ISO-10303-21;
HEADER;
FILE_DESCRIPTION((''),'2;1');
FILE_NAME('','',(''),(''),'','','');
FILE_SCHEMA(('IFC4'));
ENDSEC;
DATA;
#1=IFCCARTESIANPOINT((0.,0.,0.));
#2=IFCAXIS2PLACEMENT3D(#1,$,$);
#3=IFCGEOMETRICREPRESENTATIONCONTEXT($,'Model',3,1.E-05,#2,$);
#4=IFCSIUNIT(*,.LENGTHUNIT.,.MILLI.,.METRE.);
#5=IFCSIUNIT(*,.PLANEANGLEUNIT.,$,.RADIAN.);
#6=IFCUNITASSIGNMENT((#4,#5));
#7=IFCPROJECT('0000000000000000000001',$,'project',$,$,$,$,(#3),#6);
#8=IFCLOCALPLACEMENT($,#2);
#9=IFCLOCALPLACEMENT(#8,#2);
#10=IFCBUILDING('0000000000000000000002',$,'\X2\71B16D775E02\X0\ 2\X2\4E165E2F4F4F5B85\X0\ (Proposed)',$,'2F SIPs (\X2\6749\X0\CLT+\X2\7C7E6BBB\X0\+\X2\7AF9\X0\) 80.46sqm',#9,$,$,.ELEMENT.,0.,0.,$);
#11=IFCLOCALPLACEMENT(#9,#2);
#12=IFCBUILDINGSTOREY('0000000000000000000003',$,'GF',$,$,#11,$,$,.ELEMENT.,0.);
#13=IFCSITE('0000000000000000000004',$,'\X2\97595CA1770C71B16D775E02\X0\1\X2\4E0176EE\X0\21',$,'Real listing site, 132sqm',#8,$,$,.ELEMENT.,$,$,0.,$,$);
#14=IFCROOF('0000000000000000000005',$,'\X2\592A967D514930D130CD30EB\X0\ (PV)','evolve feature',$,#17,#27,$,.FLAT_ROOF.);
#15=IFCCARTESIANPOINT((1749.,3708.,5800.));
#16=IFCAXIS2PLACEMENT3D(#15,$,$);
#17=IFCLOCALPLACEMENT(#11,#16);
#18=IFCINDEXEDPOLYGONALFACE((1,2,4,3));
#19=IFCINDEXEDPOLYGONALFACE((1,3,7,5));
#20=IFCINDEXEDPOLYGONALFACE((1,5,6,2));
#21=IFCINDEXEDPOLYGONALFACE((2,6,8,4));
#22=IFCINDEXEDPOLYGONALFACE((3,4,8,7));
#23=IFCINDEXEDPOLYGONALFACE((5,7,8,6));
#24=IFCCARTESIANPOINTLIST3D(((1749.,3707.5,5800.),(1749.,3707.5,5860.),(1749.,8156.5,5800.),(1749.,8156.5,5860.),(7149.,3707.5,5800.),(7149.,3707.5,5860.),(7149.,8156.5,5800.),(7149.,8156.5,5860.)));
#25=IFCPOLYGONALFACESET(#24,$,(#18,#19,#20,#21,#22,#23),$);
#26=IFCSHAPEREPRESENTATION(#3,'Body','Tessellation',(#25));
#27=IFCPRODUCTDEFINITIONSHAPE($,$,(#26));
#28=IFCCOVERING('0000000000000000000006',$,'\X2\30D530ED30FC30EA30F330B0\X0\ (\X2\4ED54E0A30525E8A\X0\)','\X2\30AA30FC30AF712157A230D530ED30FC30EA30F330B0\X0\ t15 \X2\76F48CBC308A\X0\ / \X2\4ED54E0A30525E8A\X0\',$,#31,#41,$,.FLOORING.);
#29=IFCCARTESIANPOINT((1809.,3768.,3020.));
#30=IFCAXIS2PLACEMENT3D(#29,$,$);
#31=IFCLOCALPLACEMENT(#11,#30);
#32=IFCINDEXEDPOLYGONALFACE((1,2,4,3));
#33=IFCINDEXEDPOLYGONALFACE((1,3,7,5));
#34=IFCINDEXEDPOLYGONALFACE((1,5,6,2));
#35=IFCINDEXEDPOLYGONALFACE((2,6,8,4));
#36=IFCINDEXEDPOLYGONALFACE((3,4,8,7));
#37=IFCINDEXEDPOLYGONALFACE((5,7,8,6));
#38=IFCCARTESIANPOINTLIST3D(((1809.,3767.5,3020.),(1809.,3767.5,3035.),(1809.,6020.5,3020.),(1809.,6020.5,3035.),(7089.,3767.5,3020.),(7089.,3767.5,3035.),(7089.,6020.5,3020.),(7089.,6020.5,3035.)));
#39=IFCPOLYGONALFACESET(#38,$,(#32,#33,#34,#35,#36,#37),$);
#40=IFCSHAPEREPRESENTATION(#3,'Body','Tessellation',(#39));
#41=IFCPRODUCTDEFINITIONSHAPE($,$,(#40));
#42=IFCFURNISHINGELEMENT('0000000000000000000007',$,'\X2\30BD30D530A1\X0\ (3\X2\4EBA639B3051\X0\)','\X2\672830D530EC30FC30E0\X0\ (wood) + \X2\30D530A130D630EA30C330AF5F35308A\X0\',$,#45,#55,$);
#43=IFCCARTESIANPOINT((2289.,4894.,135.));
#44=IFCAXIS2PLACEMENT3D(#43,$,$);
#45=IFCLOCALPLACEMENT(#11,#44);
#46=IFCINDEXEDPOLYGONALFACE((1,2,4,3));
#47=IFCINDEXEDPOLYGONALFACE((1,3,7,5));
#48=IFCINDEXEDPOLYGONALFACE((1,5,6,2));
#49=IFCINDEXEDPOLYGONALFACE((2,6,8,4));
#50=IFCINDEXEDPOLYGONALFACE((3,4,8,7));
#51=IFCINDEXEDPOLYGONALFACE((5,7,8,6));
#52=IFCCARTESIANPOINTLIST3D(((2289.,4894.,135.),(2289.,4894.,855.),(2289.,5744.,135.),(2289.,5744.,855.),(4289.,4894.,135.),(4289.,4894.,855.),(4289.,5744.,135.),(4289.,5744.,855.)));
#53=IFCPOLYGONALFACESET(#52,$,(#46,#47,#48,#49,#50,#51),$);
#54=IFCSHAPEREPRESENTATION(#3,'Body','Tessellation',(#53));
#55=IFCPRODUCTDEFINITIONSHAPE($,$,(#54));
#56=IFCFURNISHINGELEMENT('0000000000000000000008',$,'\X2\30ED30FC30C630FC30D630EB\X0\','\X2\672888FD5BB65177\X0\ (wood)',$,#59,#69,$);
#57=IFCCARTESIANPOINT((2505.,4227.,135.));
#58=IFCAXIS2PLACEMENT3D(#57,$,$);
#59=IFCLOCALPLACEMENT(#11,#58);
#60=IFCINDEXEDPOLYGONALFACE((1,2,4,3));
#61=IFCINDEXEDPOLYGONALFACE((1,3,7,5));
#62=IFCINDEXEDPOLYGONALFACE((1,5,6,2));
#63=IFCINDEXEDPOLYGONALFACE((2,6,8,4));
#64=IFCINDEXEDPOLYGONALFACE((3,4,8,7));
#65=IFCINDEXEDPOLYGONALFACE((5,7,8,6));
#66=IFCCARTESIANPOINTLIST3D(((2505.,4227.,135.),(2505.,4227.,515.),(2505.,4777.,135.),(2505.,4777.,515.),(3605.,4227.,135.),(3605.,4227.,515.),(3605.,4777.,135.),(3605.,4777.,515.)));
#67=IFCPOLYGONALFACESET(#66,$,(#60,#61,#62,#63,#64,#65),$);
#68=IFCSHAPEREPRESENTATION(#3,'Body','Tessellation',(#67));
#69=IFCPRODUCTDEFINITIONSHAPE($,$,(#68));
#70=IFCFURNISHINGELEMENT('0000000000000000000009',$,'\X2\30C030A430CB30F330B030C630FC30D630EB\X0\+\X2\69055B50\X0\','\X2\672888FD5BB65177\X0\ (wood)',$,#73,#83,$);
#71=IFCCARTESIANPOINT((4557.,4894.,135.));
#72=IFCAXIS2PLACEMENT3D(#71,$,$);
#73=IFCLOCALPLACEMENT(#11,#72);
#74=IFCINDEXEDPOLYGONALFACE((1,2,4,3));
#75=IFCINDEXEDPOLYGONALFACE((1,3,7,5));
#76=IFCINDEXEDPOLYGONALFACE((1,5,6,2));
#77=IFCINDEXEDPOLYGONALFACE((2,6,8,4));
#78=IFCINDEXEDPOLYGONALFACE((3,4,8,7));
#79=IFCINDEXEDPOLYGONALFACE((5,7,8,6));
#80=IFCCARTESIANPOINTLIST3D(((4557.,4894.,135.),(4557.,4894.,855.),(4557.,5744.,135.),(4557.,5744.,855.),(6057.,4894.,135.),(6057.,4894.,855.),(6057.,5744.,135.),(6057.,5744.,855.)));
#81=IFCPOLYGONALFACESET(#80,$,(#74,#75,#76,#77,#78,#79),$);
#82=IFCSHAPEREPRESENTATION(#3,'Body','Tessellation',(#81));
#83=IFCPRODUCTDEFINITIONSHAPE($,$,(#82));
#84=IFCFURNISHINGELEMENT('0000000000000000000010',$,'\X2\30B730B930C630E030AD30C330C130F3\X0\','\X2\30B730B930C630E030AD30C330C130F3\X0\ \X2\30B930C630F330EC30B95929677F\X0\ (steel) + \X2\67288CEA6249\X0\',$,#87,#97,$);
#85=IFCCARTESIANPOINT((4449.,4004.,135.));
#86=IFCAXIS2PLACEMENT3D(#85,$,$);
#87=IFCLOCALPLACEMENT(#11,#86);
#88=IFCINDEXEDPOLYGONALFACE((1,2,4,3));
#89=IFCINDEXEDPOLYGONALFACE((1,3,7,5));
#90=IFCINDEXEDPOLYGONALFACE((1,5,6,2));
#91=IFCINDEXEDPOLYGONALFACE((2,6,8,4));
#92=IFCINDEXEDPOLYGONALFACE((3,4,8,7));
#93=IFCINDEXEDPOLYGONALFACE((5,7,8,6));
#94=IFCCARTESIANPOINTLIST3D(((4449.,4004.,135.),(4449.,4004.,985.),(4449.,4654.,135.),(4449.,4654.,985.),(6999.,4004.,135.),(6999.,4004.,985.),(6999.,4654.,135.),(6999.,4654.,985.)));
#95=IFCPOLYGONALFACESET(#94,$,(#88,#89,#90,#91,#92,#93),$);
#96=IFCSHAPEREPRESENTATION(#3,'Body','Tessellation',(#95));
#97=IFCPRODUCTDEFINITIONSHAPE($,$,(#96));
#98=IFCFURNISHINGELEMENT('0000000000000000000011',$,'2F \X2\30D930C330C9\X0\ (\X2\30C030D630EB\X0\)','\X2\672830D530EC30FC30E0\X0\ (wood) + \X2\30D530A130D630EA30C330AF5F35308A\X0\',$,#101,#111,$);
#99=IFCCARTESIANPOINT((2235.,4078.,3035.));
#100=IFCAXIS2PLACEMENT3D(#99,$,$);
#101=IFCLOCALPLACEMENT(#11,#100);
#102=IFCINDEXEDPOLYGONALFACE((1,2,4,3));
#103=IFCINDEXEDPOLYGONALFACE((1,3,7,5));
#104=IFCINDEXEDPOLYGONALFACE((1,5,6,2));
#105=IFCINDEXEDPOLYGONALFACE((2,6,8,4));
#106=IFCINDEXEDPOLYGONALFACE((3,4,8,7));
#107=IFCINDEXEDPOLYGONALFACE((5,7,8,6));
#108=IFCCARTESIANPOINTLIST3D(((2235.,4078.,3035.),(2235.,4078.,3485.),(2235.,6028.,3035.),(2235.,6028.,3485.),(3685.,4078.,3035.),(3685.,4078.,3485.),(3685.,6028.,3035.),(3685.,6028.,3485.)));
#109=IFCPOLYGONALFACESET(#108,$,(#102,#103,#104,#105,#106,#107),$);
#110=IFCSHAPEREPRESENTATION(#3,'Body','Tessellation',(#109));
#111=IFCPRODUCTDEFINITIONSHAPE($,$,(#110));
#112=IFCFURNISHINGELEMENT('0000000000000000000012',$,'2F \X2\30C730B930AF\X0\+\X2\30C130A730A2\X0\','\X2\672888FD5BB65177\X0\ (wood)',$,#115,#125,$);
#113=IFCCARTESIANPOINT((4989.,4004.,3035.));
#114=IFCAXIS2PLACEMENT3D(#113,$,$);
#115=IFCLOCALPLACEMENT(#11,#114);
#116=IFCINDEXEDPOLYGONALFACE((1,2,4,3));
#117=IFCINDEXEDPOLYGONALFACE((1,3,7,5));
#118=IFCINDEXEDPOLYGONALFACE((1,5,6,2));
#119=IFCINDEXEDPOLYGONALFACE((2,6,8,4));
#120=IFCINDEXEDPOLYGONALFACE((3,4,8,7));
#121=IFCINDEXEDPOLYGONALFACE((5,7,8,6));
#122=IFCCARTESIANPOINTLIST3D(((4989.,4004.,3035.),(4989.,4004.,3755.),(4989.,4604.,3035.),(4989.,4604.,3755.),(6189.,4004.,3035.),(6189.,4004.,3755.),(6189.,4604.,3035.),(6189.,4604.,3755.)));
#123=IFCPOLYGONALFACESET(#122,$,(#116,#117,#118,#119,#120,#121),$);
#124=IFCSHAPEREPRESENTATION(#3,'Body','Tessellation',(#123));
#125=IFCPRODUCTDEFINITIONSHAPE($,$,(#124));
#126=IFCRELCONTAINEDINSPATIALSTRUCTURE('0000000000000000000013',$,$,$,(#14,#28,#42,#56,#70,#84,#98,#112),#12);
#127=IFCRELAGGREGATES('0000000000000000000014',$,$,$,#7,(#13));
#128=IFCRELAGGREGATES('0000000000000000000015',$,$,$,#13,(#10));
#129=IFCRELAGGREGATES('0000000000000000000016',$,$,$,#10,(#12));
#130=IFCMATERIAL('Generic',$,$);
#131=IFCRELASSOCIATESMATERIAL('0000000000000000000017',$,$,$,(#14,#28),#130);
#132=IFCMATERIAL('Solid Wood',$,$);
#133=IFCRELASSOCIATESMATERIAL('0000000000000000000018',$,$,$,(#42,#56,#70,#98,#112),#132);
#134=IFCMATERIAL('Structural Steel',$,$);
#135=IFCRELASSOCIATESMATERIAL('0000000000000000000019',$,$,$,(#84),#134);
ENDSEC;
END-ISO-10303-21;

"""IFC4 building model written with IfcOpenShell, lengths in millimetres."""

from ifc_helpers import new_model, si_unit, frame, frame_2d, origin, place, context, project, spatial, rectangle, extrude, material, element, save


model = new_model("IFC4")

# Units and contexts
model_context = context("Model", 3, precision=1e-05, world=origin())
ifc_project = project(units=[si_unit("LENGTHUNIT", "METRE", prefix="MILLI"), si_unit("PLANEANGLEUNIT", "RADIAN")], contexts=[model_context])

# Site, building, storey
site_placement = place(None, origin())
site = spatial("IfcSite", under=ifc_project, at=site_placement, Name="静岡県熱海市1丁目21", ObjectType="Real listing site, 132sqm", CompositionType="ELEMENT", RefElevation=0.0)
building_placement = place(site_placement, origin())
building = spatial("IfcBuilding", under=site, at=building_placement, Name="熱海市 2世帯住宅 (Proposed)", ObjectType="2F SIPs (杉CLT+籾殻+竹) 80.46sqm", CompositionType="ELEMENT", ElevationOfRefHeight=0.0, ElevationOfTerrain=0.0)
storey_placement = place(building_placement, origin())
storey = spatial("IfcBuildingStorey", under=building, at=storey_placement, Name="GF", CompositionType="ELEMENT", Elevation=0.0)

# Shared definitions
ifc_material_1 = material(Name="Solid Wood")

# Shared definitions
ifc_material_2 = material(Name="Generic")

# Roof
ifc_material_3 = material(Name="Structural Steel")
roof_1_placement = place(storey_placement, frame((1749.0, 3708.0, 5800.0)))
element("IfcRoof", 1, at=roof_1_placement, inside=storey, material=ifc_material_2, Name="太陽光パネル (PV)", Description="evolve feature", PredefinedType="FLAT_ROOF", context=model_context, shape_type="SweptSolid", body=[
    extrude(rectangle(XDim=5400.0, YDim=4449.0, at=frame_2d((2700.0, 2224.0))), frame((1749.0, 3708.0, 5800.0)), (0.0, 0.0, 1.0), 60.0),
])

# Covering
covering_placement = place(storey_placement, frame((1809.0, 3768.0, 3020.0)))
element("IfcCovering", 2, at=covering_placement, inside=storey, material=ifc_material_2, Name="フローリング (仕上げ床)", Description="オーク無垢フローリング t15 直貼り / 仕上げ床", PredefinedType="FLOORING", context=model_context, shape_type="SweptSolid", body=[
    extrude(rectangle(XDim=5280.0, YDim=2253.0, at=frame_2d((2640.0, 1126.0))), frame((1809.0, 3768.0, 3020.0)), (0.0, 0.0, 1.0), 15.0),
])

# Furnishing elements
furnishing_1_placement = place(storey_placement, frame((2289.0, 4894.0, 135.0)))
element("IfcFurnishingElement", 3, at=furnishing_1_placement, inside=storey, material=ifc_material_1, Name="ソファ (3人掛け)", Description="木フレーム (wood) + ファブリック張り", context=model_context, shape_type="SweptSolid", body=[
    extrude(rectangle(XDim=2000.0, YDim=850.0, at=frame_2d((1000.0, 425.0))), frame((2289.0, 4894.0, 135.0)), (0.0, 0.0, 1.0), 720.0),
])
furnishing_2_placement = place(storey_placement, frame((2505.0, 4227.0, 135.0)))
element("IfcFurnishingElement", 4, at=furnishing_2_placement, inside=storey, material=ifc_material_1, Name="ローテーブル", Description="木製家具 (wood)", context=model_context, shape_type="SweptSolid", body=[
    extrude(rectangle(XDim=1100.0, YDim=550.0, at=frame_2d((550.0, 275.0))), frame((2505.0, 4227.0, 135.0)), (0.0, 0.0, 1.0), 380.0),
])
furnishing_3_placement = place(storey_placement, frame((4557.0, 4894.0, 135.0)))
element("IfcFurnishingElement", 5, at=furnishing_3_placement, inside=storey, material=ifc_material_1, Name="ダイニングテーブル+椅子", Description="木製家具 (wood)", context=model_context, shape_type="SweptSolid", body=[
    extrude(rectangle(XDim=1500.0, YDim=850.0, at=frame_2d((750.0, 425.0))), frame((4557.0, 4894.0, 135.0)), (0.0, 0.0, 1.0), 720.0),
])
furnishing_4_placement = place(storey_placement, frame((4449.0, 4004.0, 135.0)))
element("IfcFurnishingElement", 6, at=furnishing_4_placement, inside=storey, material=ifc_material_3, Name="システムキッチン", Description="システムキッチン ステンレス天板 (steel) + 木質扉", context=model_context, shape_type="SweptSolid", body=[
    extrude(rectangle(XDim=2550.0, YDim=650.0, at=frame_2d((1275.0, 325.0))), frame((4449.0, 4004.0, 135.0)), (0.0, 0.0, 1.0), 850.0),
])
furnishing_5_placement = place(storey_placement, frame((2235.0, 4078.0, 3035.0)))
element("IfcFurnishingElement", 7, at=furnishing_5_placement, inside=storey, material=ifc_material_1, Name="2F ベッド (ダブル)", Description="木フレーム (wood) + ファブリック張り", context=model_context, shape_type="SweptSolid", body=[
    extrude(rectangle(XDim=1450.0, YDim=1950.0, at=frame_2d((725.0, 975.0))), frame((2235.0, 4078.0, 3035.0)), (0.0, 0.0, 1.0), 450.0),
])
furnishing_6_placement = place(storey_placement, frame((4989.0, 4004.0, 3035.0)))
element("IfcFurnishingElement", 8, at=furnishing_6_placement, inside=storey, material=ifc_material_1, Name="2F デスク+チェア", Description="木製家具 (wood)", context=model_context, shape_type="SweptSolid", body=[
    extrude(rectangle(XDim=1200.0, YDim=600.0, at=frame_2d((600.0, 300.0))), frame((4989.0, 4004.0, 3035.0)), (0.0, 0.0, 1.0), 720.0),
])

save(model, "model.ifc")
